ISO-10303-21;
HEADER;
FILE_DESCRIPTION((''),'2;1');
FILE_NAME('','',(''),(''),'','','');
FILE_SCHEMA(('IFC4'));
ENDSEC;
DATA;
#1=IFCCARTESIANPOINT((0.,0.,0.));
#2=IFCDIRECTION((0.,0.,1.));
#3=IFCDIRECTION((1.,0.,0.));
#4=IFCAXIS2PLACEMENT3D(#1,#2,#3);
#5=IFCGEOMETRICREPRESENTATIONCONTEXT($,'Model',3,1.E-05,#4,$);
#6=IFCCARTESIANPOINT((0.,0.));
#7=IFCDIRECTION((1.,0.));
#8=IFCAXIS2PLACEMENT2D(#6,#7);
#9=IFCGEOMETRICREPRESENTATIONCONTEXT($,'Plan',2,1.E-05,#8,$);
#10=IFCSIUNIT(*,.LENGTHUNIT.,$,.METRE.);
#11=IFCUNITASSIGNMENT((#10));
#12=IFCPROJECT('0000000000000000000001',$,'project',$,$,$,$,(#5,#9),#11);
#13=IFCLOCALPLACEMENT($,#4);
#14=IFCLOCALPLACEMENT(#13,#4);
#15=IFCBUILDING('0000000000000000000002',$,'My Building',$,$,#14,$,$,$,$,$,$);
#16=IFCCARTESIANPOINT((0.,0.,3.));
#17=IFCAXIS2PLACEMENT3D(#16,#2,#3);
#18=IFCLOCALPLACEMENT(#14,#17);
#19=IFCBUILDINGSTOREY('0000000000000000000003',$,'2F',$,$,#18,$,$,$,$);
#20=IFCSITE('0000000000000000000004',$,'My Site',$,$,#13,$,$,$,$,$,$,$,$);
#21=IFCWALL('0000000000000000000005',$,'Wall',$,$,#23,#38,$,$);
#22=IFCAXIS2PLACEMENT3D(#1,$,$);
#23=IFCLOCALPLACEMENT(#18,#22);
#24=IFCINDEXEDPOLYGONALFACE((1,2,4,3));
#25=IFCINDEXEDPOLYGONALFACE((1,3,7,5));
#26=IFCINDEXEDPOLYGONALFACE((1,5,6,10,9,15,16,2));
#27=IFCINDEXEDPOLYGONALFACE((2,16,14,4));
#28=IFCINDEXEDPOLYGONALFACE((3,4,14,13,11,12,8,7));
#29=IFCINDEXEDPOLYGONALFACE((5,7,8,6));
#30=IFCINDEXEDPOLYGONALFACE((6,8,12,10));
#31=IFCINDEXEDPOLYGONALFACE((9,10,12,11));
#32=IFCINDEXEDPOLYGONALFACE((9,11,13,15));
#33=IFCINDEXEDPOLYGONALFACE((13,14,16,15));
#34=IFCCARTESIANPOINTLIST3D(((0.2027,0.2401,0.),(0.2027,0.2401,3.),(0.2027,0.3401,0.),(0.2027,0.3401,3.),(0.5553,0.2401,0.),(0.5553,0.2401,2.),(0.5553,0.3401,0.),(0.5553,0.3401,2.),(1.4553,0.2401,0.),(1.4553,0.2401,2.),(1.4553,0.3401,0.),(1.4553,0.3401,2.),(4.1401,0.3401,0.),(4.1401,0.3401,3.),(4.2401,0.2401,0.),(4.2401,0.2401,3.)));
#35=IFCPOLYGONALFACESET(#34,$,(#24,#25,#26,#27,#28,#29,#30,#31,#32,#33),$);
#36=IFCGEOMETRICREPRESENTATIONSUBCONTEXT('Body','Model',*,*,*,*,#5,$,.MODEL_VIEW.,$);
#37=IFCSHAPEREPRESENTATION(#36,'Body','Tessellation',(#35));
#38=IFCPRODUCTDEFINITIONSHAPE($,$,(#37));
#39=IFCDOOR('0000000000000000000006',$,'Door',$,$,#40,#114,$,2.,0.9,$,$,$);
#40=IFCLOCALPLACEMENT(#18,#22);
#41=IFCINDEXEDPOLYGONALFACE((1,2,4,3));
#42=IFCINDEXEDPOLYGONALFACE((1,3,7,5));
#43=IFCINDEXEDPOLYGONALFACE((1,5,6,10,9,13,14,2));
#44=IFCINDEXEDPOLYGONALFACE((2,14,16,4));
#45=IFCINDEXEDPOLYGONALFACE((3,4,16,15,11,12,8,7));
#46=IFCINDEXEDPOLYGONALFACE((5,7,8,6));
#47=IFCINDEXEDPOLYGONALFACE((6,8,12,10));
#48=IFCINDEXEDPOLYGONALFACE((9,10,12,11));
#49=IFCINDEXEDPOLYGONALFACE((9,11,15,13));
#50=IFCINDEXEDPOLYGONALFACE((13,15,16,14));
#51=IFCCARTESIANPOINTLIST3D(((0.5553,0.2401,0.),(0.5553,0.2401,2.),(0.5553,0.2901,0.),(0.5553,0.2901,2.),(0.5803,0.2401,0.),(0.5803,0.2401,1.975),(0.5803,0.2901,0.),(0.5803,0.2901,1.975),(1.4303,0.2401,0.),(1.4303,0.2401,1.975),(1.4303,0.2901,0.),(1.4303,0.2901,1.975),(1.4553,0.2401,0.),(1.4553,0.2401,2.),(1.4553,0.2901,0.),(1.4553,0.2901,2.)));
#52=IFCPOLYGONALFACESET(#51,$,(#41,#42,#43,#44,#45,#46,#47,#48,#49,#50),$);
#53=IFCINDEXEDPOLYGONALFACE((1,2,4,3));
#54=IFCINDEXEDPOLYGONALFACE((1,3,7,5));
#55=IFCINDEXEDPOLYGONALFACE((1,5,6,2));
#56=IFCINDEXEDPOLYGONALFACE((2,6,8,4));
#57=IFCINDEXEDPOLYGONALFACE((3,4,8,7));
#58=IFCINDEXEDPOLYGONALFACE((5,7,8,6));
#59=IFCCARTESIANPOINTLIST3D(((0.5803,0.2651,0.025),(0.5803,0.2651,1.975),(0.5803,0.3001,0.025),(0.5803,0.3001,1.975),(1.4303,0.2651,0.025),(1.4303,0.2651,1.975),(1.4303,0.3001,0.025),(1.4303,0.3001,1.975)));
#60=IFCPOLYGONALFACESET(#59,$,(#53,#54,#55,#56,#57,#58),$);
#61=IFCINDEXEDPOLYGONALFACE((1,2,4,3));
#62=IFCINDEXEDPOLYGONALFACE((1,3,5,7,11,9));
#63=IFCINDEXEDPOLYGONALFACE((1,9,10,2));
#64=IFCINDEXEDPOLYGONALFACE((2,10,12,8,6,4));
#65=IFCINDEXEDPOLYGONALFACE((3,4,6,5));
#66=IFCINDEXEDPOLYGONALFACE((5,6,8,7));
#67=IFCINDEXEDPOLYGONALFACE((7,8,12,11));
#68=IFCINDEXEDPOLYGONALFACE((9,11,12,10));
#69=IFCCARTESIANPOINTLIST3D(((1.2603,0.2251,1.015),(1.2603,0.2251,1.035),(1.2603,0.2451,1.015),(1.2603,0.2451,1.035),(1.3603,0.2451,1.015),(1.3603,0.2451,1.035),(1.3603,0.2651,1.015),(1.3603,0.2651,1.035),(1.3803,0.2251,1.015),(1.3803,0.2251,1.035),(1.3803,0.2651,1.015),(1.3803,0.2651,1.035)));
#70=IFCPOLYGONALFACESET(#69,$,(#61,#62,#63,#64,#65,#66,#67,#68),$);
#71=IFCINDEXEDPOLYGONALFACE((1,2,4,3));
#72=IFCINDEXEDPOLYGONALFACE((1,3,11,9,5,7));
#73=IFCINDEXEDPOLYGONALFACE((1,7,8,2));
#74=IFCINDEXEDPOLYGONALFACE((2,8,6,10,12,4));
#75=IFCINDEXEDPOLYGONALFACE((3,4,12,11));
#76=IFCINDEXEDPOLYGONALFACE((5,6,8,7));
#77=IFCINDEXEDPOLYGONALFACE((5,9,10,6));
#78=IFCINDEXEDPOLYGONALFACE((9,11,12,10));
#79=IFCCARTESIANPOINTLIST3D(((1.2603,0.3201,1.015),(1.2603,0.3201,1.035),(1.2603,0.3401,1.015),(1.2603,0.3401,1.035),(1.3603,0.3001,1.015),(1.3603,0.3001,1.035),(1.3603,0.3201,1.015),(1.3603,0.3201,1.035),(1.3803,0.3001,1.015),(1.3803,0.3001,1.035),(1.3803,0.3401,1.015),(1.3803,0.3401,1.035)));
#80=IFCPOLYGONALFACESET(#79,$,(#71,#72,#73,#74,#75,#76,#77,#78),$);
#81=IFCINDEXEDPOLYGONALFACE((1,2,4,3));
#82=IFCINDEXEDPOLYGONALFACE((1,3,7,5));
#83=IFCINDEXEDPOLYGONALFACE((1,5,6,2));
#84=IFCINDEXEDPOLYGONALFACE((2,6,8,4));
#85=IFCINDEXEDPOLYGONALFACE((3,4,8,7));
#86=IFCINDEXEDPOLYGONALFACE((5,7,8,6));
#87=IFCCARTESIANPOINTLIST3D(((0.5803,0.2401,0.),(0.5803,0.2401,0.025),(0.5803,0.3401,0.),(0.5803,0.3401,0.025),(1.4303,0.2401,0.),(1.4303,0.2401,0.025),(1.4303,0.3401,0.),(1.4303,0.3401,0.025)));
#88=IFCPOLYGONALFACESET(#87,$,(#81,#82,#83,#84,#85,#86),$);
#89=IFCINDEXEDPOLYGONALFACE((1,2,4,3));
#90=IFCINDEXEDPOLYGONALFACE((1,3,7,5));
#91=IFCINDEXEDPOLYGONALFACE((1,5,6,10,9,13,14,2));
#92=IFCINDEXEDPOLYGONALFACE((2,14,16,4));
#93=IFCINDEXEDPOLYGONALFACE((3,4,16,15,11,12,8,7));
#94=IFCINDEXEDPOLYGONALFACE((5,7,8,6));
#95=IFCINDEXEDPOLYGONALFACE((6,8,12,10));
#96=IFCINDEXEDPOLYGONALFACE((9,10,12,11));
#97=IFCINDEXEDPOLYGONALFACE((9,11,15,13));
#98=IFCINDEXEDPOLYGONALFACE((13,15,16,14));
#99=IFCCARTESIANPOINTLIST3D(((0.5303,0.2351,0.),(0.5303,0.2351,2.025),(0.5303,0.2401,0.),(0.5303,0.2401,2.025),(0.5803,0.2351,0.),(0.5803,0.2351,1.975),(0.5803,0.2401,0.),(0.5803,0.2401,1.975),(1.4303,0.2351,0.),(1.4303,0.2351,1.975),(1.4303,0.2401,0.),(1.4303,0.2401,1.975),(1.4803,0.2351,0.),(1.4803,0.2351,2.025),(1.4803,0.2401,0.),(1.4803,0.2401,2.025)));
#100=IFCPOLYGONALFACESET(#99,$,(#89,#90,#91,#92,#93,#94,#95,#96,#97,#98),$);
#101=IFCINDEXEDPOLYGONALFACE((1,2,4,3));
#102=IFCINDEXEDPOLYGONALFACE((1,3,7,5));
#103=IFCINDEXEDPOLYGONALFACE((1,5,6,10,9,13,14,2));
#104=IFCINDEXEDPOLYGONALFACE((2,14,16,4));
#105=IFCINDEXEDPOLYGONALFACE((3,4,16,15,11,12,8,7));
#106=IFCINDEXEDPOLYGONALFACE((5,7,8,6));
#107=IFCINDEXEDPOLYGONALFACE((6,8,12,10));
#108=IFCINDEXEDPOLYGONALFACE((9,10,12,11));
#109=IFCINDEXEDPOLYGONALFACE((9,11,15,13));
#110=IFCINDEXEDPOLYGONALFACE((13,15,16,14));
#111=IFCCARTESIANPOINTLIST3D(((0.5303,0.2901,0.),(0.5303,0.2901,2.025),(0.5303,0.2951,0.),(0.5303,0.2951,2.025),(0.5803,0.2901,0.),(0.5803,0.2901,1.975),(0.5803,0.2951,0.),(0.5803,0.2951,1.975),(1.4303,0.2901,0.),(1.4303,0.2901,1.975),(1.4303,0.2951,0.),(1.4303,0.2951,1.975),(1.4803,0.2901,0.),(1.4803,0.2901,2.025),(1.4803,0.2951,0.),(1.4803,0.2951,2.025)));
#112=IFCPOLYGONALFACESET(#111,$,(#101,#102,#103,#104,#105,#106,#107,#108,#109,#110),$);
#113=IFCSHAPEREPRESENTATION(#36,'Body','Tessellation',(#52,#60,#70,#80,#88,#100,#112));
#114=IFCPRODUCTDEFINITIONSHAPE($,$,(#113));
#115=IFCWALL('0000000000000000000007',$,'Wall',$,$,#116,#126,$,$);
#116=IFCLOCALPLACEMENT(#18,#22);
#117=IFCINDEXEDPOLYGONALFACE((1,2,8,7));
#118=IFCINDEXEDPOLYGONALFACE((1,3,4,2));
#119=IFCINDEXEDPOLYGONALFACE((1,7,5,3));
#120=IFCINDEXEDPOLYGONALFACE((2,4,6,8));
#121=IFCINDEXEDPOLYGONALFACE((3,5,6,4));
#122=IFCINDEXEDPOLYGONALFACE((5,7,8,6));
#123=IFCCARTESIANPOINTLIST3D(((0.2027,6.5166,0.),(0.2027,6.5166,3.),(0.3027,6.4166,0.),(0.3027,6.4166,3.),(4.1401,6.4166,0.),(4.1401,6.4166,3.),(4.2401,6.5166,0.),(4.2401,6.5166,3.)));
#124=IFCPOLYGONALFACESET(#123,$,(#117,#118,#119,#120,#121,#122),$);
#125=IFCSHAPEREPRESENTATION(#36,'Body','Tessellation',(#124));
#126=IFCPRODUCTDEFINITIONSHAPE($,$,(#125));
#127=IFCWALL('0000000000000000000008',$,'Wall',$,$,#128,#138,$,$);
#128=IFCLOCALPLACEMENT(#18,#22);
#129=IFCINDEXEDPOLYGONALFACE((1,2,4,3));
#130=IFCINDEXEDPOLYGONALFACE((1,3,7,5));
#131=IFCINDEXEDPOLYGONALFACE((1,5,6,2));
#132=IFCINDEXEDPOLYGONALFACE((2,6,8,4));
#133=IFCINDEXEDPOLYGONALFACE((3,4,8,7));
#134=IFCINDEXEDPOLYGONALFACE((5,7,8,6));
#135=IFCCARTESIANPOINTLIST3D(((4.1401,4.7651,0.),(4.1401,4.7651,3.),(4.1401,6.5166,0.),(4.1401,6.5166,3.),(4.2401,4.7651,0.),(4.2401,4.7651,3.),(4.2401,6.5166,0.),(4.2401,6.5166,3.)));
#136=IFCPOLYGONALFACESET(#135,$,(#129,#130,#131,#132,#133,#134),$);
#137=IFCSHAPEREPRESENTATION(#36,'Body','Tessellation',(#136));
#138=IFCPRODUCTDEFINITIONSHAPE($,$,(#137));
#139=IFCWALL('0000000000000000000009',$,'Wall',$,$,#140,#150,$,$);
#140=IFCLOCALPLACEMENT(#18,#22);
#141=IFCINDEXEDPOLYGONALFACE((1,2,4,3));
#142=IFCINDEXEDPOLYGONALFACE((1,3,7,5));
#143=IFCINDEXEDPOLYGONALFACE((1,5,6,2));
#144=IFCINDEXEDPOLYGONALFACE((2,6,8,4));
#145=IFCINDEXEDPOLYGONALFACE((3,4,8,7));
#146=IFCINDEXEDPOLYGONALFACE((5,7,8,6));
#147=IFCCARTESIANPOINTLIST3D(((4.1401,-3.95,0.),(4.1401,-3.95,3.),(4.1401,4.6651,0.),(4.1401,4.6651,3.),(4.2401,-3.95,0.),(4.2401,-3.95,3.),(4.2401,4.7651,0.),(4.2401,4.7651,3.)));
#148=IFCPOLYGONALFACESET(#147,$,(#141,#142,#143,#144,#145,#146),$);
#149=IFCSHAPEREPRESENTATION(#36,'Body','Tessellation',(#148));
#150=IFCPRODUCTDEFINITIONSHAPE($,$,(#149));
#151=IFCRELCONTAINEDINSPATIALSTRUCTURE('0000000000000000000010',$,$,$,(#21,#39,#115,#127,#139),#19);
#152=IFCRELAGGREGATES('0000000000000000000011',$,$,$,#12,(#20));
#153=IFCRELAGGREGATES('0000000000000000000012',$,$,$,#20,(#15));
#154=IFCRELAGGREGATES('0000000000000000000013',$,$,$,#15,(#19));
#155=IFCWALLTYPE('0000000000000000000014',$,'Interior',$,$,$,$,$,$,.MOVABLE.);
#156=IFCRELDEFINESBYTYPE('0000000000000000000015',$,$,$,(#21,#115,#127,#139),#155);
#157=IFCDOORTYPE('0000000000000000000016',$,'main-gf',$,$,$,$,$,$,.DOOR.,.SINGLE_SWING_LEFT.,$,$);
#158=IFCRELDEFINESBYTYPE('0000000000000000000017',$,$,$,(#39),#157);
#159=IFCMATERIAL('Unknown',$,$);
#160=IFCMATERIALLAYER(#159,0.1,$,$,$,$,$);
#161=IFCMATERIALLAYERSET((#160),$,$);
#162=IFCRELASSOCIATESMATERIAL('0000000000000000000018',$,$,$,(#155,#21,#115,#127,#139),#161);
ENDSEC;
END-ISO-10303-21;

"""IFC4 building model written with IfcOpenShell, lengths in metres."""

from ifc_helpers import new_model, entity, si_unit, frame, origin_with_axes, origin_2d_with_axis, place, context, subcontext, project, spatial, line, indexed_curve, outline, extrude, shape, source, transform, mapped, material, layer, layer_set, layer_usage, type_object, type_shapes, element, fill, save


model = new_model("IFC4")

# Units and contexts
model_context = context("Model", 3, precision=1e-05, world=origin_with_axes())
plan_context = context("Plan", 2, precision=1e-05, world=origin_2d_with_axis())
body_context_1 = subcontext(model_context, "Body", "Model", "MODEL_VIEW")
body_context_2 = subcontext(plan_context, "Body", "Plan", "PLAN_VIEW")
ifc_project = project(units=[si_unit("LENGTHUNIT", "METRE")], contexts=[model_context, plan_context])

# Site, building, storey
site_placement = place(None, origin_with_axes())
site = spatial("IfcSite", under=ifc_project, at=site_placement, Name="My Site")
building_placement = place(site_placement, origin_with_axes())
building = spatial("IfcBuilding", under=site, at=building_placement, Name="My Building")
storey_placement = place(building_placement, frame((0.0, 0.0, 3.0), z_axis=(0.0, 0.0, 1.0), x_axis=(1.0, 0.0, 0.0)))
storey = spatial("IfcBuildingStorey", under=building, at=storey_placement, Name="2F")

# Shared definitions
ifc_material = material(Name="Unknown")

# Shared definitions
ifc_layer_1 = layer(ifc_material, 0.1)
ifc_layer_set_1 = layer_set([ifc_layer_1])
wall_type = type_object("IfcWallType", Name="Interior", PredefinedType="MOVABLE", material=ifc_layer_set_1)

# Shared definitions
shared_shape_1 = source(origin_with_axes(), body_context_1, "Body", "SweptSolid", [
    extrude(outline(indexed_curve([(0.0, 0.0), (0.9, 0.0), (0.9, 2.0), (0.0, 2.0)], segments=[line(1, 2, 3, 4, 1)])), frame((0.0, -0.6, 0.0), z_axis=(0.0, -1.0, 0.0), x_axis=(1.0, 0.0, 0.0)), (0.0, 0.0, -1.0), 1.2),
])
door_type = type_object("IfcDoorType", Name="main-gf", OperationType="SINGLE_SWING_LEFT", PredefinedType="DOOR")
shared_shape_2 = source(origin_with_axes(), body_context_1, "Body", "SweptSolid", [
    extrude(outline(indexed_curve([(0.0, 0.0), (0.0, 2.0), (0.9, 2.0), (0.9, 0.0), (0.875, 0.0), (0.875, 1.975), (0.025, 1.975), (0.025, 0.0)], segments=[line(1, 2, 3, 4, 5, 6, 7, 8, 1)])), frame((0.0, 0.0, 0.0), z_axis=(0.0, -1.0, 0.0), x_axis=(1.0, 0.0, 0.0)), (0.0, 0.0, -1.0), 0.05),
    extrude(outline(indexed_curve([(0.0, 0.0), (0.85, 0.0), (0.85, 0.035), (0.0, 0.035)], segments=[line(1, 2, 3, 4, 1)])), frame((0.025, 0.025, 0.025), z_axis=(0.0, 0.0, 1.0), x_axis=(1.0, 0.0, 0.0)), (0.0, 0.0, 1.0), 1.95),
    extrude(outline(indexed_curve([(0.0, 0.0), (0.0, -0.04), (-0.12, -0.04), (-0.12, -0.02), (-0.02, -0.02), (-0.02, 0.0)], segments=[line(1, 2, 3, 4, 5, 6, 1)])), frame((0.825, 0.025, 1.015), z_axis=(0.0, 0.0, 1.0), x_axis=(1.0, 0.0, 0.0)), (0.0, 0.0, 1.0), 0.02),
    extrude(outline(indexed_curve([(0.0, 0.0), (0.0, 0.04), (-0.12, 0.04), (-0.12, 0.02), (-0.02, 0.02), (-0.02, 0.0)], segments=[line(1, 2, 3, 4, 5, 6, 1)])), frame((0.825, 0.06, 1.015), z_axis=(0.0, 0.0, 1.0), x_axis=(1.0, 0.0, 0.0)), (0.0, 0.0, 1.0), 0.02),
    extrude(outline(indexed_curve([(0.0, 0.0), (0.85, 0.0), (0.85, 0.1), (0.0, 0.1)], segments=[line(1, 2, 3, 4, 1)])), frame((0.025, 0.0, 0.0), z_axis=(0.0, 0.0, 1.0), x_axis=(1.0, 0.0, 0.0)), (0.0, 0.0, 1.0), 0.025),
    extrude(outline(indexed_curve([(0.0, 0.0), (0.0, 2.025), (0.95, 2.025), (0.95, 0.0), (0.9, 0.0), (0.9, 1.975), (0.05, 1.975), (0.05, 0.0)], segments=[line(1, 2, 3, 4, 5, 6, 7, 8, 1)])), frame((-0.025, -0.005, 0.0), z_axis=(0.0, -1.0, 0.0), x_axis=(1.0, 0.0, 0.0)), (0.0, 0.0, -1.0), 0.005),
    extrude(outline(indexed_curve([(0.0, 0.0), (0.0, 2.025), (0.95, 2.025), (0.95, 0.0), (0.9, 0.0), (0.9, 1.975), (0.05, 1.975), (0.05, 0.0)], segments=[line(1, 2, 3, 4, 5, 6, 7, 8, 1)])), frame((-0.025, 0.05, 0.0), z_axis=(0.0, -1.0, 0.0), x_axis=(1.0, 0.0, 0.0)), (0.0, 0.0, -1.0), 0.005),
])
shared_shape_3 = source(origin_with_axes(), body_context_2, "Body", "Curve2D", [
    entity("IfcIndexedPolyCurve", entity("IfcCartesianPointList2D", [[0.0, 0.0], [0.025, 0.0], [0.025, 0.05], [0.0, 0.05]]), [entity("IfcLineIndex", [1, 2, 3, 4, 1])]),
    entity("IfcIndexedPolyCurve", entity("IfcCartesianPointList2D", [[0.9, 0.0], [0.875, 0.0], [0.875, 0.05], [0.9, 0.05]]), [entity("IfcLineIndex", [1, 2, 3, 4, 1])]),
    entity("IfcIndexedPolyCurve", entity("IfcCartesianPointList2D", [[0.025, 0.05], [0.025, -0.8], [0.06, -0.8]])),
    entity("IfcTrimmedCurve", entity("IfcEllipse", entity("IfcAxis2Placement2D", entity("IfcCartesianPoint", [0.06, 0.05]), entity("IfcDirection", [1.0, 0.0])), 0.815, 0.85), [entity("IfcCartesianPoint", [0.06, -0.8])], [entity("IfcCartesianPoint", [0.06, 0.9])], True, "CARTESIAN"),
    entity("IfcIndexedPolyCurve", entity("IfcCartesianPointList2D", [[0.025, 0.05], [0.06, 0.05], [0.06, 0.9], [0.025, 0.9]]), [entity("IfcLineIndex", [1, 2, 3, 4, 1])]),
])
type_shapes(door_type, [shared_shape_2, shared_shape_3])

# Wall, opening, door
ifc_layer_usage_1 = layer_usage(ifc_layer_set_1, "AXIS2", "POSITIVE", 0.0)
wall_1_placement = place(storey_placement, frame((4.1401, 0.3401, 0.0), z_axis=(0.0, 0.0, 1.0), x_axis=(-1.0, 0.0, 0.0)))
wall_1 = element("IfcWall", 1, at=wall_1_placement, inside=storey, type_object=wall_type, material=ifc_layer_usage_1, Name="Wall", context=body_context_1, shape_type="SweptSolid", body=[
    extrude(outline(indexed_curve([(0.0, 0.0), (-0.1, 0.1), (3.9374, 0.1), (3.9374, 0.0)], segments=[line(1, 2, 3, 4, 1)])), origin_with_axes(), (0.0, 0.0, 1.0), 3.0),
])
opening_1_placement = place(wall_1_placement, frame((3.5848, 0.1, 0.0), z_axis=(0.0, 0.0, 1.0), x_axis=(-1.0, 0.0, 0.0)))
opening_1 = element("IfcOpeningElement", 2, at=opening_1_placement, cuts=wall_1, PredefinedType="OPENING", context=body_context_1, shape_type="MappedRepresentation", body=[
    mapped(shared_shape_1, transform((0.0, 0.0, 0.0), x_axis=(1.0, 0.0, 0.0), y_axis=(0.0, 1.0, 0.0), z_axis=(0.0, 0.0, 1.0), scale=1.0)),
])
door_1_placement = place(opening_1_placement, frame((0.0, 0.0, 0.0), z_axis=(0.0, 0.0, 1.0), x_axis=(1.0, 0.0, 0.0)))
door_1 = element("IfcDoor", 3, at=door_1_placement, inside=storey, type_object=door_type, Name="Door", OverallHeight=2.0, OverallWidth=0.9, shapes=[
    shape(body_context_1, "Body", "MappedRepresentation", [mapped(shared_shape_2, transform((0.0, 0.0, 0.0), x_axis=(1.0, 0.0, 0.0), y_axis=(0.0, 1.0, 0.0), z_axis=(0.0, 0.0, 1.0), scale=1.0))]),
    shape(body_context_2, "Body", "MappedRepresentation", [mapped(shared_shape_3, transform((0.0, 0.0, 0.0), x_axis=(1.0, 0.0, 0.0), y_axis=(0.0, 1.0, 0.0), z_axis=(0.0, 0.0, 1.0), scale=1.0))]),
])
fill(opening_1, door_1)

# Walls
ifc_layer_usage_2 = layer_usage(ifc_layer_set_1, "AXIS2", "POSITIVE", 0.0)
wall_2_placement = place(storey_placement, frame((4.2401, 6.5166, 0.0), z_axis=(0.0, 0.0, 1.0), x_axis=(-1.0, 0.0, 0.0)))
element("IfcWall", 4, at=wall_2_placement, inside=storey, type_object=wall_type, material=ifc_layer_usage_2, Name="Wall", context=body_context_1, shape_type="SweptSolid", body=[
    extrude(outline(indexed_curve([(0.0, 0.0), (0.1, 0.1), (3.9373, 0.1), (4.0373, 0.0)], segments=[line(1, 2, 3, 4, 1)])), origin_with_axes(), (0.0, 0.0, 1.0), 3.0),
])
ifc_layer_usage_3 = layer_usage(ifc_layer_set_1, "AXIS2", "POSITIVE", 0.0)
wall_3_placement = place(storey_placement, frame((4.2401, 4.7651, 0.0), z_axis=(0.0, 0.0, 1.0), x_axis=(0.0, 1.0, 0.0)))
element("IfcWall", 5, at=wall_3_placement, inside=storey, type_object=wall_type, material=ifc_layer_usage_3, Name="Wall", context=body_context_1, shape_type="SweptSolid", body=[
    extrude(outline(indexed_curve([(0.0, 0.0), (0.0, 0.1), (1.7515, 0.1), (1.7515, 0.0)], segments=[line(1, 2, 3, 4, 1)])), origin_with_axes(), (0.0, 0.0, 1.0), 3.0),
])
ifc_layer_usage_4 = layer_usage(ifc_layer_set_1, "AXIS2", "POSITIVE", 0.0)
wall_4_placement = place(storey_placement, frame((4.1401, 4.7651, 0.0), z_axis=(0.0, 0.0, 1.0), x_axis=(0.0, -1.0, 0.0)))
element("IfcWall", 6, at=wall_4_placement, inside=storey, type_object=wall_type, material=ifc_layer_usage_4, Name="Wall", context=body_context_1, shape_type="SweptSolid", body=[
    extrude(outline(indexed_curve([(0.1, 0.0), (0.0, 0.1), (8.7151, 0.1), (8.7151, 0.0)], segments=[line(1, 2, 3, 4, 1)])), origin_with_axes(), (0.0, 0.0, 1.0), 3.0),
])

save(model, "model.ifc")
